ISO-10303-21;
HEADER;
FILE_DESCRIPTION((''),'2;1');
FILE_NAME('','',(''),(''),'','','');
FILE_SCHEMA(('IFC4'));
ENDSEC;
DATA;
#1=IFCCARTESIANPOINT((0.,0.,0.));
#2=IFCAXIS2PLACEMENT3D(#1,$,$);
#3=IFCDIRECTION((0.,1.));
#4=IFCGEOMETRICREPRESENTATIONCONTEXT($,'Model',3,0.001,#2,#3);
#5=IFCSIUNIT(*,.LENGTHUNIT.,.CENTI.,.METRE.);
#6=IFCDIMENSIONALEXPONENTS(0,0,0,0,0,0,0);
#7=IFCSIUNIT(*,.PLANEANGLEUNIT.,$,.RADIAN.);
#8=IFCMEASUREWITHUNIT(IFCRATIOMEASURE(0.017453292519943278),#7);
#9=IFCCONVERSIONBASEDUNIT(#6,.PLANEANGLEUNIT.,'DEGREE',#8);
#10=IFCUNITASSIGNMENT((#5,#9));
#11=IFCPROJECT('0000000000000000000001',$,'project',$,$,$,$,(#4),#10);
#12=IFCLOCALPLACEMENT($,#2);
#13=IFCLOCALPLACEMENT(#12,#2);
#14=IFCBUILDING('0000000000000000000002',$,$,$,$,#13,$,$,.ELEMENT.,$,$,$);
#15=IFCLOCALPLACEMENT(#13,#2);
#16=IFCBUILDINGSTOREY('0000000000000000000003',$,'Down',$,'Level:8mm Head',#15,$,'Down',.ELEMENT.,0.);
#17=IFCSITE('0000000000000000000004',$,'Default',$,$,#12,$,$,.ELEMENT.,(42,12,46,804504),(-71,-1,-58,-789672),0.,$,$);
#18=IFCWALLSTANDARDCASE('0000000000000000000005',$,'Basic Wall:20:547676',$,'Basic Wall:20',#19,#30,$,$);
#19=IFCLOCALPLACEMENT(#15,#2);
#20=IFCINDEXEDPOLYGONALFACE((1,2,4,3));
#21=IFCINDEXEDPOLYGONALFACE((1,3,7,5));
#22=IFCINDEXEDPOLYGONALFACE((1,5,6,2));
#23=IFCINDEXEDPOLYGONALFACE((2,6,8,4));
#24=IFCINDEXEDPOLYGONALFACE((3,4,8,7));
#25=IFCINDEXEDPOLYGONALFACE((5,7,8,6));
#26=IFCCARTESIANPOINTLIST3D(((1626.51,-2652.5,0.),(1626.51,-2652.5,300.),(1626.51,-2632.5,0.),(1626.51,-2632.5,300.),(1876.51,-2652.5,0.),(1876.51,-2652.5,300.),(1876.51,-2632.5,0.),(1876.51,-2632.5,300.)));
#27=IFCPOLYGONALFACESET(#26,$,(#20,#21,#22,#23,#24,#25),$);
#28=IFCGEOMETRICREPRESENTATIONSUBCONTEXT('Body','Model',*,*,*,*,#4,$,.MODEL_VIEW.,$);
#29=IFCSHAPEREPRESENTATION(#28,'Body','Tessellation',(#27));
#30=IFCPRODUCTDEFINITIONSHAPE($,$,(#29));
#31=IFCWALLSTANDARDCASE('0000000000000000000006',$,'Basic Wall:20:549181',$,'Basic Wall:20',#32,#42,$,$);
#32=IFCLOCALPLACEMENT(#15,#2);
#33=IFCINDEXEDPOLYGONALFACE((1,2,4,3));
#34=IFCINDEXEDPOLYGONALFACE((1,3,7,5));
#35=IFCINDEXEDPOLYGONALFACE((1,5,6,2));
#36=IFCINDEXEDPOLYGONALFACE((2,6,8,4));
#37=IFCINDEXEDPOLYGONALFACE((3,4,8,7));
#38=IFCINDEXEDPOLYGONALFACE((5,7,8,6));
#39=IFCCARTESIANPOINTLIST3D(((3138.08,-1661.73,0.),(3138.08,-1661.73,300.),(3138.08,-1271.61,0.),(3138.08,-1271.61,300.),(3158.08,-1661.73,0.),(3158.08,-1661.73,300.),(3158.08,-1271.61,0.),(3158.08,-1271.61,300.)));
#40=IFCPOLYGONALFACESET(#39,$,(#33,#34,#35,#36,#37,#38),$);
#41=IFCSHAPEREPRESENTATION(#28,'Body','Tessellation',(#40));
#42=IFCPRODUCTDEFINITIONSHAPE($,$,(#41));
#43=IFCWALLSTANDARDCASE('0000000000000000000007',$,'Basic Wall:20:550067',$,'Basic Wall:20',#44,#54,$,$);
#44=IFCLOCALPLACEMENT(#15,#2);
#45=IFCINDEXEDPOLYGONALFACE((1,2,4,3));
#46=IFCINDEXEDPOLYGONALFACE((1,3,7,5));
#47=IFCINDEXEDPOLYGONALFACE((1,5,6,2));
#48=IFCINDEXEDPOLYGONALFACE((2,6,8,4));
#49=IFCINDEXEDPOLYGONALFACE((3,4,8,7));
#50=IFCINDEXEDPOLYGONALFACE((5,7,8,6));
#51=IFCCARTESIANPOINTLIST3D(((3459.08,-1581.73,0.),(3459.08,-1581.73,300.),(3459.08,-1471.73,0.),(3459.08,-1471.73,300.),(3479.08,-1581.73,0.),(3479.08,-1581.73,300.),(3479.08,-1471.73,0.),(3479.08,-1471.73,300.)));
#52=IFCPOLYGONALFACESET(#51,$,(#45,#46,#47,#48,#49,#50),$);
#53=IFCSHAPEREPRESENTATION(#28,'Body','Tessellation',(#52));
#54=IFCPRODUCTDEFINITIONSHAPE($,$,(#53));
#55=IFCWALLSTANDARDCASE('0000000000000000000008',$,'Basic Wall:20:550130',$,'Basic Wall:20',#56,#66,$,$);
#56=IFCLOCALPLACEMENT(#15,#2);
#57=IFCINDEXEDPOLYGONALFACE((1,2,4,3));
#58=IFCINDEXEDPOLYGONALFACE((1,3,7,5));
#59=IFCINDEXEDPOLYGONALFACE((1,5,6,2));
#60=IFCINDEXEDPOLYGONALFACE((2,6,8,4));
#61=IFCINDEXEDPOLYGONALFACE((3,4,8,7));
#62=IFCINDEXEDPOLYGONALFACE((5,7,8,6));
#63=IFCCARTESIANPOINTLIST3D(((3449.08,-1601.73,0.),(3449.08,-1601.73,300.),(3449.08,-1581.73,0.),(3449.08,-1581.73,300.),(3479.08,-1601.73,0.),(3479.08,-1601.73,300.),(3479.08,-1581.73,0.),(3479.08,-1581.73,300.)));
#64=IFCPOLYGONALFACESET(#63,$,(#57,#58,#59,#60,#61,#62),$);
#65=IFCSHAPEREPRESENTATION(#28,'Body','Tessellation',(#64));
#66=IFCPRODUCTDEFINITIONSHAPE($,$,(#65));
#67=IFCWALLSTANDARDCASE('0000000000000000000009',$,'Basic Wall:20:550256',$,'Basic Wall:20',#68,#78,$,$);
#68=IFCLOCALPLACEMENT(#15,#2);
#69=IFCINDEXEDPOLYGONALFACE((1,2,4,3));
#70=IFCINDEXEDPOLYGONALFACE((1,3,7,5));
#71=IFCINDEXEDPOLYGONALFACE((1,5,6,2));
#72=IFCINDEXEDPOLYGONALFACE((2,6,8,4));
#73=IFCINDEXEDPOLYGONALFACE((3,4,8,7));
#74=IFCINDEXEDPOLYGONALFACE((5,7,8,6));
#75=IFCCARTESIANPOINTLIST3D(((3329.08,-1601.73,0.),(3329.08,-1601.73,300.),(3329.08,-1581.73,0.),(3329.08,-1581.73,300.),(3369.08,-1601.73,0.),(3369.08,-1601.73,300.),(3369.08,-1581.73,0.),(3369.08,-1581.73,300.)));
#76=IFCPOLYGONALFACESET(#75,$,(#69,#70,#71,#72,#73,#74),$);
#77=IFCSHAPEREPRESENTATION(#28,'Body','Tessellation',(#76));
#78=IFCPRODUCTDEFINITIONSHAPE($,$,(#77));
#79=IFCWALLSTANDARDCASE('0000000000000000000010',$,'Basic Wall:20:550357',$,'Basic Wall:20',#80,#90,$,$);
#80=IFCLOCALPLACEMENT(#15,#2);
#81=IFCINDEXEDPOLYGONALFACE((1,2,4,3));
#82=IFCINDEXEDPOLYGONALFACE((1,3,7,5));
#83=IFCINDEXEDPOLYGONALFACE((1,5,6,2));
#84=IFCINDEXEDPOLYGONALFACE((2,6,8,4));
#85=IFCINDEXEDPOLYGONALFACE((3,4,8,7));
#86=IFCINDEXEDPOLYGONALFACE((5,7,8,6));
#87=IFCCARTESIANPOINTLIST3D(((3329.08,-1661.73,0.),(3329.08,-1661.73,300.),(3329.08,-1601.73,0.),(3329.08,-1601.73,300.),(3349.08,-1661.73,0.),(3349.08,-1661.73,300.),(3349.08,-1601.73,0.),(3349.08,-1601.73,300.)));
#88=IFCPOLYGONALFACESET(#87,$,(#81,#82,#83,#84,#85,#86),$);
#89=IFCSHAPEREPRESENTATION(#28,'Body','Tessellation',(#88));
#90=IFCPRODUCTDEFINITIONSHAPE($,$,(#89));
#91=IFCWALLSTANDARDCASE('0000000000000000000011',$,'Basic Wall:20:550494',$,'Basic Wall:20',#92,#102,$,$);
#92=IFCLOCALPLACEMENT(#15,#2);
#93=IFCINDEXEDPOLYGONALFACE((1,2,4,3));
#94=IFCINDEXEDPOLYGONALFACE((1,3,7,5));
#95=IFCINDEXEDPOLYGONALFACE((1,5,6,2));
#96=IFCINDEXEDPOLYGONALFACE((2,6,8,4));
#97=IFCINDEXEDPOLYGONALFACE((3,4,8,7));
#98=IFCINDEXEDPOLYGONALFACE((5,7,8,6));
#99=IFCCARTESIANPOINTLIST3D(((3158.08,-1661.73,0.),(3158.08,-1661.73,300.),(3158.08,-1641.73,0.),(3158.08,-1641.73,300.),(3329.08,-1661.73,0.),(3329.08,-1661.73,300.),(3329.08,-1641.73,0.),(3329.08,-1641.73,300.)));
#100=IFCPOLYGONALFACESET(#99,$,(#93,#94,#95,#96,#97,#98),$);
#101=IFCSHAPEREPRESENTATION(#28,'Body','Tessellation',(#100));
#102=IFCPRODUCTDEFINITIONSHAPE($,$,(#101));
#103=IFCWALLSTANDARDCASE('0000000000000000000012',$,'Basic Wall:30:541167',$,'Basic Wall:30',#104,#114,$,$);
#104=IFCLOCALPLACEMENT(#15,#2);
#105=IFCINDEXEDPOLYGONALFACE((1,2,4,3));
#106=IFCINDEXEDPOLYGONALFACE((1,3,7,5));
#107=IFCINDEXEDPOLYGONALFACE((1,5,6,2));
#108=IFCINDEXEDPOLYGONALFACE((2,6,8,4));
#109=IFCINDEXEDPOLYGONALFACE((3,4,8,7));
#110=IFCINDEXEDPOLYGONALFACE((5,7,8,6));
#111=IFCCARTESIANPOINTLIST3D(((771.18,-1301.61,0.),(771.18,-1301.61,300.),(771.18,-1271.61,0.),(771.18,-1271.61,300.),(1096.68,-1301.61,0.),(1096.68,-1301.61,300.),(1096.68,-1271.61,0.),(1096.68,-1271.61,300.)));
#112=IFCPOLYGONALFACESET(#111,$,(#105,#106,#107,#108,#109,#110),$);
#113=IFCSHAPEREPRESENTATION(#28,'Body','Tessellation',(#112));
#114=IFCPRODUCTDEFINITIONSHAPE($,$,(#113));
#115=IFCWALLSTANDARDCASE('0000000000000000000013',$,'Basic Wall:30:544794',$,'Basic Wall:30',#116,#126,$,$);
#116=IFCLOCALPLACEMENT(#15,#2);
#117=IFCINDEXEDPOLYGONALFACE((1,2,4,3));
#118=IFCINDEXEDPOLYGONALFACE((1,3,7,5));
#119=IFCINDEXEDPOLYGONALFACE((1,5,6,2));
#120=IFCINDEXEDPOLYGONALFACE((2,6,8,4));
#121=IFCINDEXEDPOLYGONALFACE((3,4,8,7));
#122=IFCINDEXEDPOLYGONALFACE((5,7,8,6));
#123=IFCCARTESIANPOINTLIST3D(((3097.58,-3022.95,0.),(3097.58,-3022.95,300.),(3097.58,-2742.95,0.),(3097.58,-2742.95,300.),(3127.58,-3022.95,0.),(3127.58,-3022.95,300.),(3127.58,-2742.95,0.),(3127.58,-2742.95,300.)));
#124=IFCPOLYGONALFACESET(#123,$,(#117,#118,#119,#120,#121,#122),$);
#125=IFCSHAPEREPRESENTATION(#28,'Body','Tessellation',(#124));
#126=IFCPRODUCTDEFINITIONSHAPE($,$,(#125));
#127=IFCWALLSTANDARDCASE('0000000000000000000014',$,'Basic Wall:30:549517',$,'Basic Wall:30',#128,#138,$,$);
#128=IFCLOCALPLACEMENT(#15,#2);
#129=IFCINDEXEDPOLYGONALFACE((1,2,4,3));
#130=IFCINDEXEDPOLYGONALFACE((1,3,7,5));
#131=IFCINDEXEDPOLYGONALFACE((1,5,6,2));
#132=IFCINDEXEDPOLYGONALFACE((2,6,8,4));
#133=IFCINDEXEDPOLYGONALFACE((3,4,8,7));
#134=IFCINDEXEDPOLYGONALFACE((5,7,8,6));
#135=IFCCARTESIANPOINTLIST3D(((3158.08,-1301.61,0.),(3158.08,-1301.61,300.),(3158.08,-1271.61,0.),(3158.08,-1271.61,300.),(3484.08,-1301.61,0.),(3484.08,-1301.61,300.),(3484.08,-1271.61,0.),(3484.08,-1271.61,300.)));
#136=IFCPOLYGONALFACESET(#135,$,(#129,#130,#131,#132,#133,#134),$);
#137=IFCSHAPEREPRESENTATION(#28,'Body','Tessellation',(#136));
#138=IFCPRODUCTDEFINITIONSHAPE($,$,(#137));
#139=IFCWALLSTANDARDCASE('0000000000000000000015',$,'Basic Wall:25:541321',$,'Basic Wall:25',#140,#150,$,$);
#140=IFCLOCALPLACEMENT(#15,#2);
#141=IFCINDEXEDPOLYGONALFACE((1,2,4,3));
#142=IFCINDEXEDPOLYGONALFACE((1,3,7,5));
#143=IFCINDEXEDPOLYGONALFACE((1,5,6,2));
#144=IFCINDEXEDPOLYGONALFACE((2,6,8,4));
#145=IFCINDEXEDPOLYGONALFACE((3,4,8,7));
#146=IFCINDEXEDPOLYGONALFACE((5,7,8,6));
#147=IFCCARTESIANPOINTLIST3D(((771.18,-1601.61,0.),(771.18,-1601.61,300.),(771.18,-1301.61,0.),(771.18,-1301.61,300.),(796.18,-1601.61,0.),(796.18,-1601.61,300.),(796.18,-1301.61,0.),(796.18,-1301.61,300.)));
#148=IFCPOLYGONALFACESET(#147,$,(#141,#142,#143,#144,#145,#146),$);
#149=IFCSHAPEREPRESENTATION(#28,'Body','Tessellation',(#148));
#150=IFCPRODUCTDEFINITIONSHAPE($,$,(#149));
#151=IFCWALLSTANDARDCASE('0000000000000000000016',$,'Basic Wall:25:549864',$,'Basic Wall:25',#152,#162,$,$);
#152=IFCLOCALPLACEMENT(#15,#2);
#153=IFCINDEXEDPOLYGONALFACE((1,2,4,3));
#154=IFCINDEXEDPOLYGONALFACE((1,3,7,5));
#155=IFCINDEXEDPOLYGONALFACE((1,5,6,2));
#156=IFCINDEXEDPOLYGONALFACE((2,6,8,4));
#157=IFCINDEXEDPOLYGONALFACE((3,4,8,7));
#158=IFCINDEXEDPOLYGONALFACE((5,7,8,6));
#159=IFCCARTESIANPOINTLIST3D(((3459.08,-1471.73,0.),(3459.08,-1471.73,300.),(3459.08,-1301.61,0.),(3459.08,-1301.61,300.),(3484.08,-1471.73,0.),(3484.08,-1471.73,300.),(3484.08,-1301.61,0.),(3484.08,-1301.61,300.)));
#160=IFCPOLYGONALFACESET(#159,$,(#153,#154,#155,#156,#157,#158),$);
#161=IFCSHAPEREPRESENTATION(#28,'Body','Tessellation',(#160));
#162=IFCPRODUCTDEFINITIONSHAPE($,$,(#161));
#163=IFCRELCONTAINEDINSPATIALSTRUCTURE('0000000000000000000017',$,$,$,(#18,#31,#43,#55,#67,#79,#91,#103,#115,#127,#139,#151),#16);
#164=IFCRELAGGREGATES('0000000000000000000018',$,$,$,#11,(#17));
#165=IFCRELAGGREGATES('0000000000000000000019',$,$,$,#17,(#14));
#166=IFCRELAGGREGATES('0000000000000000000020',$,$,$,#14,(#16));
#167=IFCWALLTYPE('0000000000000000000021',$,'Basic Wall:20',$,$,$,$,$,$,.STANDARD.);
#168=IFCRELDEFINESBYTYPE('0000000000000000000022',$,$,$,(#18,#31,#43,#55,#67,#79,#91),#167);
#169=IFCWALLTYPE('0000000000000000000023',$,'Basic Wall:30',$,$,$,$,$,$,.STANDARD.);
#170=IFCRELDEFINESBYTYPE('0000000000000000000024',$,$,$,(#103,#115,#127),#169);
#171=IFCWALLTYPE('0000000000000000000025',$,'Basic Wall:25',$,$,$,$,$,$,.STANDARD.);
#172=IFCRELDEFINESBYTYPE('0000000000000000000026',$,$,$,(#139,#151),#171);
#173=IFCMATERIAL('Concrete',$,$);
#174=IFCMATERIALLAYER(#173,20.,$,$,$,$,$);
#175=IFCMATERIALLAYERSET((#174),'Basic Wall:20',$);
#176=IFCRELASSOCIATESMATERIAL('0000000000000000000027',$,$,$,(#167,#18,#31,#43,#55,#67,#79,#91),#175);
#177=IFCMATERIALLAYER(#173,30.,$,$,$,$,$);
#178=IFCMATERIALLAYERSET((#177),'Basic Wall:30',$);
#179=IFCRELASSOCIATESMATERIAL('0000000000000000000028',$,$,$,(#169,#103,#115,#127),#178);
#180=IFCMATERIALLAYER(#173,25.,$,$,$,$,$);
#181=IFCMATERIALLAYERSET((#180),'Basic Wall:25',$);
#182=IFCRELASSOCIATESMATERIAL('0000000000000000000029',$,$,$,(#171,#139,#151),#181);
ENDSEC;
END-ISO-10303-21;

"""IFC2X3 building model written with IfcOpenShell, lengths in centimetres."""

from ifc_helpers import new_model, entity, si_unit, converted_unit, direction, frame, frame_2d, origin, place, context, subcontext, project, spatial, rectangle, extrude, material, layer, layer_set, layer_usage, type_object, element, save


model = new_model("IFC2X3")

# Units and contexts
model_context = context("Model", 3, precision=0.001, world=origin(), true_north=direction((0.0, 1.0)))
body_context = subcontext(model_context, "Body", "Model", "MODEL_VIEW")
ifc_project = project(units=[si_unit("LENGTHUNIT", "METRE", prefix="CENTI"), converted_unit("PLANEANGLEUNIT", "DEGREE", entity("IfcRatioMeasure", 0.017453292519943278), si_unit("PLANEANGLEUNIT", "RADIAN"), dimensions=[0, 0, 0, 0, 0, 0, 0])], contexts=[model_context])

# Site, building, storey
site_placement = place(None, origin())
site = spatial("IfcSite", under=ifc_project, at=site_placement, Name="Default", CompositionType="ELEMENT", RefLatitude=(42, 12, 46, 804504), RefLongitude=(-71, -1, -58, -789672), RefElevation=0.0)
building_placement = place(site_placement, origin())
building = spatial("IfcBuilding", under=site, at=building_placement, CompositionType="ELEMENT")
storey_placement = place(building_placement, origin())
storey = spatial("IfcBuildingStorey", under=building, at=storey_placement, Name="Down", ObjectType="Level:8mm Head", LongName="Down", CompositionType="ELEMENT", Elevation=0.0)

# Shared definitions
ifc_material = material(Name="Concrete")

# Walls
ifc_layer_1 = layer(ifc_material, 20.0)
ifc_layer_set_1 = layer_set([ifc_layer_1], Name="Basic Wall:20")
wall_type_1 = type_object("IfcWallType", Name="Basic Wall:20", PredefinedType="STANDARD", material=ifc_layer_set_1)
ifc_layer_usage_1 = layer_usage(ifc_layer_set_1, "AXIS2", "POSITIVE", -10.0)
wall_1_placement = place(storey_placement, frame((1626.51, -2642.5, 0.0)))
element("IfcWallStandardCase", 1, at=wall_1_placement, inside=storey, type_object=wall_type_1, material=ifc_layer_usage_1, Name="Basic Wall:20:547676", ObjectType="Basic Wall:20", context=body_context, shape_type="SweptSolid", body=[
    extrude(rectangle(XDim=250.0, YDim=20.0, at=frame_2d((125.0, 0.0), x_axis=(-1.0, 0.0))), origin(), (0.0, 0.0, 1.0), 300.0),
])
ifc_layer_usage_2 = layer_usage(ifc_layer_set_1, "AXIS2", "NEGATIVE", 10.0)
wall_2_placement = place(storey_placement, frame((3148.08, -1661.73, 0.0), z_axis=(0.0, 0.0, 1.0), x_axis=(0.0, 1.0, 0.0)))
element("IfcWallStandardCase", 2, at=wall_2_placement, inside=storey, type_object=wall_type_1, material=ifc_layer_usage_2, Name="Basic Wall:20:549181", ObjectType="Basic Wall:20", context=body_context, shape_type="SweptSolid", body=[
    extrude(rectangle(XDim=390.12, YDim=20.0, at=frame_2d((195.06, 0.0), x_axis=(-1.0, 0.0))), origin(), (0.0, 0.0, 1.0), 300.0),
])
ifc_layer_usage_3 = layer_usage(ifc_layer_set_1, "AXIS2", "POSITIVE", -10.0)
wall_3_placement = place(storey_placement, frame((3469.08, -1471.73, 0.0), z_axis=(0.0, 0.0, 1.0), x_axis=(0.0, -1.0, 0.0)))
element("IfcWallStandardCase", 3, at=wall_3_placement, inside=storey, type_object=wall_type_1, material=ifc_layer_usage_3, Name="Basic Wall:20:550067", ObjectType="Basic Wall:20", context=body_context, shape_type="SweptSolid", body=[
    extrude(rectangle(XDim=110.0, YDim=20.0, at=frame_2d((55.0, 0.0), x_axis=(-1.0, 0.0))), origin(), (0.0, 0.0, 1.0), 300.0),
])
ifc_layer_usage_4 = layer_usage(ifc_layer_set_1, "AXIS2", "NEGATIVE", 10.0)
wall_4_placement = place(storey_placement, frame((3479.08, -1591.73, 0.0), z_axis=(0.0, 0.0, 1.0), x_axis=(-1.0, 0.0, 0.0)))
element("IfcWallStandardCase", 4, at=wall_4_placement, inside=storey, type_object=wall_type_1, material=ifc_layer_usage_4, Name="Basic Wall:20:550130", ObjectType="Basic Wall:20", context=body_context, shape_type="SweptSolid", body=[
    extrude(rectangle(XDim=30.0, YDim=20.0, at=frame_2d((15.0, 0.0), x_axis=(-1.0, 0.0))), origin(), (0.0, 0.0, 1.0), 300.0),
])
ifc_layer_usage_5 = layer_usage(ifc_layer_set_1, "AXIS2", "NEGATIVE", 10.0)
wall_5_placement = place(storey_placement, frame((3369.08, -1591.73, 0.0), z_axis=(0.0, 0.0, 1.0), x_axis=(-1.0, 0.0, 0.0)))
element("IfcWallStandardCase", 5, at=wall_5_placement, inside=storey, type_object=wall_type_1, material=ifc_layer_usage_5, Name="Basic Wall:20:550256", ObjectType="Basic Wall:20", context=body_context, shape_type="SweptSolid", body=[
    extrude(rectangle(XDim=40.0, YDim=20.0, at=frame_2d((20.0, 0.0), x_axis=(-1.0, 0.0))), origin(), (0.0, 0.0, 1.0), 300.0),
])
ifc_layer_usage_6 = layer_usage(ifc_layer_set_1, "AXIS2", "POSITIVE", -10.0)
wall_6_placement = place(storey_placement, frame((3339.08, -1601.73, 0.0), z_axis=(0.0, 0.0, 1.0), x_axis=(0.0, -1.0, 0.0)))
element("IfcWallStandardCase", 6, at=wall_6_placement, inside=storey, type_object=wall_type_1, material=ifc_layer_usage_6, Name="Basic Wall:20:550357", ObjectType="Basic Wall:20", context=body_context, shape_type="SweptSolid", body=[
    extrude(rectangle(XDim=60.0, YDim=20.0, at=frame_2d((30.0, 0.0), x_axis=(-1.0, 0.0))), origin(), (0.0, 0.0, 1.0), 300.0),
])
ifc_layer_usage_7 = layer_usage(ifc_layer_set_1, "AXIS2", "NEGATIVE", 10.0)
wall_7_placement = place(storey_placement, frame((3329.08, -1651.73, 0.0), z_axis=(0.0, 0.0, 1.0), x_axis=(-1.0, 0.0, 0.0)))
element("IfcWallStandardCase", 7, at=wall_7_placement, inside=storey, type_object=wall_type_1, material=ifc_layer_usage_7, Name="Basic Wall:20:550494", ObjectType="Basic Wall:20", context=body_context, shape_type="SweptSolid", body=[
    extrude(rectangle(XDim=171.0, YDim=20.0, at=frame_2d((85.5, 0.0), x_axis=(-1.0, 0.0))), origin(), (0.0, 0.0, 1.0), 300.0),
])
ifc_layer_2 = layer(ifc_material, 30.0)
ifc_layer_set_2 = layer_set([ifc_layer_2], Name="Basic Wall:30")
ifc_layer_usage_8 = layer_usage(ifc_layer_set_2, "AXIS2", "POSITIVE", -15.0)
wall_type_2 = type_object("IfcWallType", Name="Basic Wall:30", PredefinedType="STANDARD", material=ifc_layer_set_2)
wall_8_placement = place(storey_placement, frame((1096.68, -1286.61, 0.0), z_axis=(0.0, 0.0, 1.0), x_axis=(-1.0, 0.0, 0.0)))
element("IfcWallStandardCase", 8, at=wall_8_placement, inside=storey, type_object=wall_type_2, material=ifc_layer_usage_8, Name="Basic Wall:30:541167", ObjectType="Basic Wall:30", context=body_context, shape_type="SweptSolid", body=[
    extrude(rectangle(XDim=325.5, YDim=30.0, at=frame_2d((162.75, 0.0), x_axis=(-1.0, 0.0))), origin(), (0.0, 0.0, 1.0), 300.0),
])
ifc_layer_usage_9 = layer_usage(ifc_layer_set_2, "AXIS2", "POSITIVE", -15.0)
wall_9_placement = place(storey_placement, frame((3112.58, -2742.95, 0.0), z_axis=(0.0, 0.0, 1.0), x_axis=(0.0, -1.0, 0.0)))
element("IfcWallStandardCase", 9, at=wall_9_placement, inside=storey, type_object=wall_type_2, material=ifc_layer_usage_9, Name="Basic Wall:30:544794", ObjectType="Basic Wall:30", context=body_context, shape_type="SweptSolid", body=[
    extrude(rectangle(XDim=280.0, YDim=30.0, at=frame_2d((140.0, 0.0), x_axis=(-1.0, 0.0))), origin(), (0.0, 0.0, 1.0), 300.0),
])
ifc_layer_usage_10 = layer_usage(ifc_layer_set_2, "AXIS2", "NEGATIVE", 15.0)
wall_10_placement = place(storey_placement, frame((3158.08, -1286.61, 0.0)))
element("IfcWallStandardCase", 10, at=wall_10_placement, inside=storey, type_object=wall_type_2, material=ifc_layer_usage_10, Name="Basic Wall:30:549517", ObjectType="Basic Wall:30", context=body_context, shape_type="SweptSolid", body=[
    extrude(rectangle(XDim=326.0, YDim=30.0, at=frame_2d((163.0, 0.0), x_axis=(-1.0, 0.0))), origin(), (0.0, 0.0, 1.0), 300.0),
])
ifc_layer_3 = layer(ifc_material, 25.0)
ifc_layer_set_3 = layer_set([ifc_layer_3], Name="Basic Wall:25")
ifc_layer_usage_11 = layer_usage(ifc_layer_set_3, "AXIS2", "POSITIVE", -12.5)
wall_type_3 = type_object("IfcWallType", Name="Basic Wall:25", PredefinedType="STANDARD", material=ifc_layer_set_3)
wall_11_placement = place(storey_placement, frame((783.68, -1301.61, 0.0), z_axis=(0.0, 0.0, 1.0), x_axis=(0.0, -1.0, 0.0)))
element("IfcWallStandardCase", 11, at=wall_11_placement, inside=storey, type_object=wall_type_3, material=ifc_layer_usage_11, Name="Basic Wall:25:541321", ObjectType="Basic Wall:25", context=body_context, shape_type="SweptSolid", body=[
    extrude(rectangle(XDim=300.0, YDim=25.0, at=frame_2d((150.0, 0.0), x_axis=(-1.0, 0.0))), origin(), (0.0, 0.0, 1.0), 300.0),
])
ifc_layer_usage_12 = layer_usage(ifc_layer_set_3, "AXIS2", "NEGATIVE", 12.5)
wall_12_placement = place(storey_placement, frame((3471.58, -1301.61, 0.0), z_axis=(0.0, 0.0, 1.0), x_axis=(0.0, -1.0, 0.0)))
element("IfcWallStandardCase", 12, at=wall_12_placement, inside=storey, type_object=wall_type_3, material=ifc_layer_usage_12, Name="Basic Wall:25:549864", ObjectType="Basic Wall:25", context=body_context, shape_type="SweptSolid", body=[
    extrude(rectangle(XDim=170.12, YDim=25.0, at=frame_2d((85.06, 0.0), x_axis=(-1.0, 0.0))), origin(), (0.0, 0.0, 1.0), 300.0),
])

save(model, "model.ifc")
